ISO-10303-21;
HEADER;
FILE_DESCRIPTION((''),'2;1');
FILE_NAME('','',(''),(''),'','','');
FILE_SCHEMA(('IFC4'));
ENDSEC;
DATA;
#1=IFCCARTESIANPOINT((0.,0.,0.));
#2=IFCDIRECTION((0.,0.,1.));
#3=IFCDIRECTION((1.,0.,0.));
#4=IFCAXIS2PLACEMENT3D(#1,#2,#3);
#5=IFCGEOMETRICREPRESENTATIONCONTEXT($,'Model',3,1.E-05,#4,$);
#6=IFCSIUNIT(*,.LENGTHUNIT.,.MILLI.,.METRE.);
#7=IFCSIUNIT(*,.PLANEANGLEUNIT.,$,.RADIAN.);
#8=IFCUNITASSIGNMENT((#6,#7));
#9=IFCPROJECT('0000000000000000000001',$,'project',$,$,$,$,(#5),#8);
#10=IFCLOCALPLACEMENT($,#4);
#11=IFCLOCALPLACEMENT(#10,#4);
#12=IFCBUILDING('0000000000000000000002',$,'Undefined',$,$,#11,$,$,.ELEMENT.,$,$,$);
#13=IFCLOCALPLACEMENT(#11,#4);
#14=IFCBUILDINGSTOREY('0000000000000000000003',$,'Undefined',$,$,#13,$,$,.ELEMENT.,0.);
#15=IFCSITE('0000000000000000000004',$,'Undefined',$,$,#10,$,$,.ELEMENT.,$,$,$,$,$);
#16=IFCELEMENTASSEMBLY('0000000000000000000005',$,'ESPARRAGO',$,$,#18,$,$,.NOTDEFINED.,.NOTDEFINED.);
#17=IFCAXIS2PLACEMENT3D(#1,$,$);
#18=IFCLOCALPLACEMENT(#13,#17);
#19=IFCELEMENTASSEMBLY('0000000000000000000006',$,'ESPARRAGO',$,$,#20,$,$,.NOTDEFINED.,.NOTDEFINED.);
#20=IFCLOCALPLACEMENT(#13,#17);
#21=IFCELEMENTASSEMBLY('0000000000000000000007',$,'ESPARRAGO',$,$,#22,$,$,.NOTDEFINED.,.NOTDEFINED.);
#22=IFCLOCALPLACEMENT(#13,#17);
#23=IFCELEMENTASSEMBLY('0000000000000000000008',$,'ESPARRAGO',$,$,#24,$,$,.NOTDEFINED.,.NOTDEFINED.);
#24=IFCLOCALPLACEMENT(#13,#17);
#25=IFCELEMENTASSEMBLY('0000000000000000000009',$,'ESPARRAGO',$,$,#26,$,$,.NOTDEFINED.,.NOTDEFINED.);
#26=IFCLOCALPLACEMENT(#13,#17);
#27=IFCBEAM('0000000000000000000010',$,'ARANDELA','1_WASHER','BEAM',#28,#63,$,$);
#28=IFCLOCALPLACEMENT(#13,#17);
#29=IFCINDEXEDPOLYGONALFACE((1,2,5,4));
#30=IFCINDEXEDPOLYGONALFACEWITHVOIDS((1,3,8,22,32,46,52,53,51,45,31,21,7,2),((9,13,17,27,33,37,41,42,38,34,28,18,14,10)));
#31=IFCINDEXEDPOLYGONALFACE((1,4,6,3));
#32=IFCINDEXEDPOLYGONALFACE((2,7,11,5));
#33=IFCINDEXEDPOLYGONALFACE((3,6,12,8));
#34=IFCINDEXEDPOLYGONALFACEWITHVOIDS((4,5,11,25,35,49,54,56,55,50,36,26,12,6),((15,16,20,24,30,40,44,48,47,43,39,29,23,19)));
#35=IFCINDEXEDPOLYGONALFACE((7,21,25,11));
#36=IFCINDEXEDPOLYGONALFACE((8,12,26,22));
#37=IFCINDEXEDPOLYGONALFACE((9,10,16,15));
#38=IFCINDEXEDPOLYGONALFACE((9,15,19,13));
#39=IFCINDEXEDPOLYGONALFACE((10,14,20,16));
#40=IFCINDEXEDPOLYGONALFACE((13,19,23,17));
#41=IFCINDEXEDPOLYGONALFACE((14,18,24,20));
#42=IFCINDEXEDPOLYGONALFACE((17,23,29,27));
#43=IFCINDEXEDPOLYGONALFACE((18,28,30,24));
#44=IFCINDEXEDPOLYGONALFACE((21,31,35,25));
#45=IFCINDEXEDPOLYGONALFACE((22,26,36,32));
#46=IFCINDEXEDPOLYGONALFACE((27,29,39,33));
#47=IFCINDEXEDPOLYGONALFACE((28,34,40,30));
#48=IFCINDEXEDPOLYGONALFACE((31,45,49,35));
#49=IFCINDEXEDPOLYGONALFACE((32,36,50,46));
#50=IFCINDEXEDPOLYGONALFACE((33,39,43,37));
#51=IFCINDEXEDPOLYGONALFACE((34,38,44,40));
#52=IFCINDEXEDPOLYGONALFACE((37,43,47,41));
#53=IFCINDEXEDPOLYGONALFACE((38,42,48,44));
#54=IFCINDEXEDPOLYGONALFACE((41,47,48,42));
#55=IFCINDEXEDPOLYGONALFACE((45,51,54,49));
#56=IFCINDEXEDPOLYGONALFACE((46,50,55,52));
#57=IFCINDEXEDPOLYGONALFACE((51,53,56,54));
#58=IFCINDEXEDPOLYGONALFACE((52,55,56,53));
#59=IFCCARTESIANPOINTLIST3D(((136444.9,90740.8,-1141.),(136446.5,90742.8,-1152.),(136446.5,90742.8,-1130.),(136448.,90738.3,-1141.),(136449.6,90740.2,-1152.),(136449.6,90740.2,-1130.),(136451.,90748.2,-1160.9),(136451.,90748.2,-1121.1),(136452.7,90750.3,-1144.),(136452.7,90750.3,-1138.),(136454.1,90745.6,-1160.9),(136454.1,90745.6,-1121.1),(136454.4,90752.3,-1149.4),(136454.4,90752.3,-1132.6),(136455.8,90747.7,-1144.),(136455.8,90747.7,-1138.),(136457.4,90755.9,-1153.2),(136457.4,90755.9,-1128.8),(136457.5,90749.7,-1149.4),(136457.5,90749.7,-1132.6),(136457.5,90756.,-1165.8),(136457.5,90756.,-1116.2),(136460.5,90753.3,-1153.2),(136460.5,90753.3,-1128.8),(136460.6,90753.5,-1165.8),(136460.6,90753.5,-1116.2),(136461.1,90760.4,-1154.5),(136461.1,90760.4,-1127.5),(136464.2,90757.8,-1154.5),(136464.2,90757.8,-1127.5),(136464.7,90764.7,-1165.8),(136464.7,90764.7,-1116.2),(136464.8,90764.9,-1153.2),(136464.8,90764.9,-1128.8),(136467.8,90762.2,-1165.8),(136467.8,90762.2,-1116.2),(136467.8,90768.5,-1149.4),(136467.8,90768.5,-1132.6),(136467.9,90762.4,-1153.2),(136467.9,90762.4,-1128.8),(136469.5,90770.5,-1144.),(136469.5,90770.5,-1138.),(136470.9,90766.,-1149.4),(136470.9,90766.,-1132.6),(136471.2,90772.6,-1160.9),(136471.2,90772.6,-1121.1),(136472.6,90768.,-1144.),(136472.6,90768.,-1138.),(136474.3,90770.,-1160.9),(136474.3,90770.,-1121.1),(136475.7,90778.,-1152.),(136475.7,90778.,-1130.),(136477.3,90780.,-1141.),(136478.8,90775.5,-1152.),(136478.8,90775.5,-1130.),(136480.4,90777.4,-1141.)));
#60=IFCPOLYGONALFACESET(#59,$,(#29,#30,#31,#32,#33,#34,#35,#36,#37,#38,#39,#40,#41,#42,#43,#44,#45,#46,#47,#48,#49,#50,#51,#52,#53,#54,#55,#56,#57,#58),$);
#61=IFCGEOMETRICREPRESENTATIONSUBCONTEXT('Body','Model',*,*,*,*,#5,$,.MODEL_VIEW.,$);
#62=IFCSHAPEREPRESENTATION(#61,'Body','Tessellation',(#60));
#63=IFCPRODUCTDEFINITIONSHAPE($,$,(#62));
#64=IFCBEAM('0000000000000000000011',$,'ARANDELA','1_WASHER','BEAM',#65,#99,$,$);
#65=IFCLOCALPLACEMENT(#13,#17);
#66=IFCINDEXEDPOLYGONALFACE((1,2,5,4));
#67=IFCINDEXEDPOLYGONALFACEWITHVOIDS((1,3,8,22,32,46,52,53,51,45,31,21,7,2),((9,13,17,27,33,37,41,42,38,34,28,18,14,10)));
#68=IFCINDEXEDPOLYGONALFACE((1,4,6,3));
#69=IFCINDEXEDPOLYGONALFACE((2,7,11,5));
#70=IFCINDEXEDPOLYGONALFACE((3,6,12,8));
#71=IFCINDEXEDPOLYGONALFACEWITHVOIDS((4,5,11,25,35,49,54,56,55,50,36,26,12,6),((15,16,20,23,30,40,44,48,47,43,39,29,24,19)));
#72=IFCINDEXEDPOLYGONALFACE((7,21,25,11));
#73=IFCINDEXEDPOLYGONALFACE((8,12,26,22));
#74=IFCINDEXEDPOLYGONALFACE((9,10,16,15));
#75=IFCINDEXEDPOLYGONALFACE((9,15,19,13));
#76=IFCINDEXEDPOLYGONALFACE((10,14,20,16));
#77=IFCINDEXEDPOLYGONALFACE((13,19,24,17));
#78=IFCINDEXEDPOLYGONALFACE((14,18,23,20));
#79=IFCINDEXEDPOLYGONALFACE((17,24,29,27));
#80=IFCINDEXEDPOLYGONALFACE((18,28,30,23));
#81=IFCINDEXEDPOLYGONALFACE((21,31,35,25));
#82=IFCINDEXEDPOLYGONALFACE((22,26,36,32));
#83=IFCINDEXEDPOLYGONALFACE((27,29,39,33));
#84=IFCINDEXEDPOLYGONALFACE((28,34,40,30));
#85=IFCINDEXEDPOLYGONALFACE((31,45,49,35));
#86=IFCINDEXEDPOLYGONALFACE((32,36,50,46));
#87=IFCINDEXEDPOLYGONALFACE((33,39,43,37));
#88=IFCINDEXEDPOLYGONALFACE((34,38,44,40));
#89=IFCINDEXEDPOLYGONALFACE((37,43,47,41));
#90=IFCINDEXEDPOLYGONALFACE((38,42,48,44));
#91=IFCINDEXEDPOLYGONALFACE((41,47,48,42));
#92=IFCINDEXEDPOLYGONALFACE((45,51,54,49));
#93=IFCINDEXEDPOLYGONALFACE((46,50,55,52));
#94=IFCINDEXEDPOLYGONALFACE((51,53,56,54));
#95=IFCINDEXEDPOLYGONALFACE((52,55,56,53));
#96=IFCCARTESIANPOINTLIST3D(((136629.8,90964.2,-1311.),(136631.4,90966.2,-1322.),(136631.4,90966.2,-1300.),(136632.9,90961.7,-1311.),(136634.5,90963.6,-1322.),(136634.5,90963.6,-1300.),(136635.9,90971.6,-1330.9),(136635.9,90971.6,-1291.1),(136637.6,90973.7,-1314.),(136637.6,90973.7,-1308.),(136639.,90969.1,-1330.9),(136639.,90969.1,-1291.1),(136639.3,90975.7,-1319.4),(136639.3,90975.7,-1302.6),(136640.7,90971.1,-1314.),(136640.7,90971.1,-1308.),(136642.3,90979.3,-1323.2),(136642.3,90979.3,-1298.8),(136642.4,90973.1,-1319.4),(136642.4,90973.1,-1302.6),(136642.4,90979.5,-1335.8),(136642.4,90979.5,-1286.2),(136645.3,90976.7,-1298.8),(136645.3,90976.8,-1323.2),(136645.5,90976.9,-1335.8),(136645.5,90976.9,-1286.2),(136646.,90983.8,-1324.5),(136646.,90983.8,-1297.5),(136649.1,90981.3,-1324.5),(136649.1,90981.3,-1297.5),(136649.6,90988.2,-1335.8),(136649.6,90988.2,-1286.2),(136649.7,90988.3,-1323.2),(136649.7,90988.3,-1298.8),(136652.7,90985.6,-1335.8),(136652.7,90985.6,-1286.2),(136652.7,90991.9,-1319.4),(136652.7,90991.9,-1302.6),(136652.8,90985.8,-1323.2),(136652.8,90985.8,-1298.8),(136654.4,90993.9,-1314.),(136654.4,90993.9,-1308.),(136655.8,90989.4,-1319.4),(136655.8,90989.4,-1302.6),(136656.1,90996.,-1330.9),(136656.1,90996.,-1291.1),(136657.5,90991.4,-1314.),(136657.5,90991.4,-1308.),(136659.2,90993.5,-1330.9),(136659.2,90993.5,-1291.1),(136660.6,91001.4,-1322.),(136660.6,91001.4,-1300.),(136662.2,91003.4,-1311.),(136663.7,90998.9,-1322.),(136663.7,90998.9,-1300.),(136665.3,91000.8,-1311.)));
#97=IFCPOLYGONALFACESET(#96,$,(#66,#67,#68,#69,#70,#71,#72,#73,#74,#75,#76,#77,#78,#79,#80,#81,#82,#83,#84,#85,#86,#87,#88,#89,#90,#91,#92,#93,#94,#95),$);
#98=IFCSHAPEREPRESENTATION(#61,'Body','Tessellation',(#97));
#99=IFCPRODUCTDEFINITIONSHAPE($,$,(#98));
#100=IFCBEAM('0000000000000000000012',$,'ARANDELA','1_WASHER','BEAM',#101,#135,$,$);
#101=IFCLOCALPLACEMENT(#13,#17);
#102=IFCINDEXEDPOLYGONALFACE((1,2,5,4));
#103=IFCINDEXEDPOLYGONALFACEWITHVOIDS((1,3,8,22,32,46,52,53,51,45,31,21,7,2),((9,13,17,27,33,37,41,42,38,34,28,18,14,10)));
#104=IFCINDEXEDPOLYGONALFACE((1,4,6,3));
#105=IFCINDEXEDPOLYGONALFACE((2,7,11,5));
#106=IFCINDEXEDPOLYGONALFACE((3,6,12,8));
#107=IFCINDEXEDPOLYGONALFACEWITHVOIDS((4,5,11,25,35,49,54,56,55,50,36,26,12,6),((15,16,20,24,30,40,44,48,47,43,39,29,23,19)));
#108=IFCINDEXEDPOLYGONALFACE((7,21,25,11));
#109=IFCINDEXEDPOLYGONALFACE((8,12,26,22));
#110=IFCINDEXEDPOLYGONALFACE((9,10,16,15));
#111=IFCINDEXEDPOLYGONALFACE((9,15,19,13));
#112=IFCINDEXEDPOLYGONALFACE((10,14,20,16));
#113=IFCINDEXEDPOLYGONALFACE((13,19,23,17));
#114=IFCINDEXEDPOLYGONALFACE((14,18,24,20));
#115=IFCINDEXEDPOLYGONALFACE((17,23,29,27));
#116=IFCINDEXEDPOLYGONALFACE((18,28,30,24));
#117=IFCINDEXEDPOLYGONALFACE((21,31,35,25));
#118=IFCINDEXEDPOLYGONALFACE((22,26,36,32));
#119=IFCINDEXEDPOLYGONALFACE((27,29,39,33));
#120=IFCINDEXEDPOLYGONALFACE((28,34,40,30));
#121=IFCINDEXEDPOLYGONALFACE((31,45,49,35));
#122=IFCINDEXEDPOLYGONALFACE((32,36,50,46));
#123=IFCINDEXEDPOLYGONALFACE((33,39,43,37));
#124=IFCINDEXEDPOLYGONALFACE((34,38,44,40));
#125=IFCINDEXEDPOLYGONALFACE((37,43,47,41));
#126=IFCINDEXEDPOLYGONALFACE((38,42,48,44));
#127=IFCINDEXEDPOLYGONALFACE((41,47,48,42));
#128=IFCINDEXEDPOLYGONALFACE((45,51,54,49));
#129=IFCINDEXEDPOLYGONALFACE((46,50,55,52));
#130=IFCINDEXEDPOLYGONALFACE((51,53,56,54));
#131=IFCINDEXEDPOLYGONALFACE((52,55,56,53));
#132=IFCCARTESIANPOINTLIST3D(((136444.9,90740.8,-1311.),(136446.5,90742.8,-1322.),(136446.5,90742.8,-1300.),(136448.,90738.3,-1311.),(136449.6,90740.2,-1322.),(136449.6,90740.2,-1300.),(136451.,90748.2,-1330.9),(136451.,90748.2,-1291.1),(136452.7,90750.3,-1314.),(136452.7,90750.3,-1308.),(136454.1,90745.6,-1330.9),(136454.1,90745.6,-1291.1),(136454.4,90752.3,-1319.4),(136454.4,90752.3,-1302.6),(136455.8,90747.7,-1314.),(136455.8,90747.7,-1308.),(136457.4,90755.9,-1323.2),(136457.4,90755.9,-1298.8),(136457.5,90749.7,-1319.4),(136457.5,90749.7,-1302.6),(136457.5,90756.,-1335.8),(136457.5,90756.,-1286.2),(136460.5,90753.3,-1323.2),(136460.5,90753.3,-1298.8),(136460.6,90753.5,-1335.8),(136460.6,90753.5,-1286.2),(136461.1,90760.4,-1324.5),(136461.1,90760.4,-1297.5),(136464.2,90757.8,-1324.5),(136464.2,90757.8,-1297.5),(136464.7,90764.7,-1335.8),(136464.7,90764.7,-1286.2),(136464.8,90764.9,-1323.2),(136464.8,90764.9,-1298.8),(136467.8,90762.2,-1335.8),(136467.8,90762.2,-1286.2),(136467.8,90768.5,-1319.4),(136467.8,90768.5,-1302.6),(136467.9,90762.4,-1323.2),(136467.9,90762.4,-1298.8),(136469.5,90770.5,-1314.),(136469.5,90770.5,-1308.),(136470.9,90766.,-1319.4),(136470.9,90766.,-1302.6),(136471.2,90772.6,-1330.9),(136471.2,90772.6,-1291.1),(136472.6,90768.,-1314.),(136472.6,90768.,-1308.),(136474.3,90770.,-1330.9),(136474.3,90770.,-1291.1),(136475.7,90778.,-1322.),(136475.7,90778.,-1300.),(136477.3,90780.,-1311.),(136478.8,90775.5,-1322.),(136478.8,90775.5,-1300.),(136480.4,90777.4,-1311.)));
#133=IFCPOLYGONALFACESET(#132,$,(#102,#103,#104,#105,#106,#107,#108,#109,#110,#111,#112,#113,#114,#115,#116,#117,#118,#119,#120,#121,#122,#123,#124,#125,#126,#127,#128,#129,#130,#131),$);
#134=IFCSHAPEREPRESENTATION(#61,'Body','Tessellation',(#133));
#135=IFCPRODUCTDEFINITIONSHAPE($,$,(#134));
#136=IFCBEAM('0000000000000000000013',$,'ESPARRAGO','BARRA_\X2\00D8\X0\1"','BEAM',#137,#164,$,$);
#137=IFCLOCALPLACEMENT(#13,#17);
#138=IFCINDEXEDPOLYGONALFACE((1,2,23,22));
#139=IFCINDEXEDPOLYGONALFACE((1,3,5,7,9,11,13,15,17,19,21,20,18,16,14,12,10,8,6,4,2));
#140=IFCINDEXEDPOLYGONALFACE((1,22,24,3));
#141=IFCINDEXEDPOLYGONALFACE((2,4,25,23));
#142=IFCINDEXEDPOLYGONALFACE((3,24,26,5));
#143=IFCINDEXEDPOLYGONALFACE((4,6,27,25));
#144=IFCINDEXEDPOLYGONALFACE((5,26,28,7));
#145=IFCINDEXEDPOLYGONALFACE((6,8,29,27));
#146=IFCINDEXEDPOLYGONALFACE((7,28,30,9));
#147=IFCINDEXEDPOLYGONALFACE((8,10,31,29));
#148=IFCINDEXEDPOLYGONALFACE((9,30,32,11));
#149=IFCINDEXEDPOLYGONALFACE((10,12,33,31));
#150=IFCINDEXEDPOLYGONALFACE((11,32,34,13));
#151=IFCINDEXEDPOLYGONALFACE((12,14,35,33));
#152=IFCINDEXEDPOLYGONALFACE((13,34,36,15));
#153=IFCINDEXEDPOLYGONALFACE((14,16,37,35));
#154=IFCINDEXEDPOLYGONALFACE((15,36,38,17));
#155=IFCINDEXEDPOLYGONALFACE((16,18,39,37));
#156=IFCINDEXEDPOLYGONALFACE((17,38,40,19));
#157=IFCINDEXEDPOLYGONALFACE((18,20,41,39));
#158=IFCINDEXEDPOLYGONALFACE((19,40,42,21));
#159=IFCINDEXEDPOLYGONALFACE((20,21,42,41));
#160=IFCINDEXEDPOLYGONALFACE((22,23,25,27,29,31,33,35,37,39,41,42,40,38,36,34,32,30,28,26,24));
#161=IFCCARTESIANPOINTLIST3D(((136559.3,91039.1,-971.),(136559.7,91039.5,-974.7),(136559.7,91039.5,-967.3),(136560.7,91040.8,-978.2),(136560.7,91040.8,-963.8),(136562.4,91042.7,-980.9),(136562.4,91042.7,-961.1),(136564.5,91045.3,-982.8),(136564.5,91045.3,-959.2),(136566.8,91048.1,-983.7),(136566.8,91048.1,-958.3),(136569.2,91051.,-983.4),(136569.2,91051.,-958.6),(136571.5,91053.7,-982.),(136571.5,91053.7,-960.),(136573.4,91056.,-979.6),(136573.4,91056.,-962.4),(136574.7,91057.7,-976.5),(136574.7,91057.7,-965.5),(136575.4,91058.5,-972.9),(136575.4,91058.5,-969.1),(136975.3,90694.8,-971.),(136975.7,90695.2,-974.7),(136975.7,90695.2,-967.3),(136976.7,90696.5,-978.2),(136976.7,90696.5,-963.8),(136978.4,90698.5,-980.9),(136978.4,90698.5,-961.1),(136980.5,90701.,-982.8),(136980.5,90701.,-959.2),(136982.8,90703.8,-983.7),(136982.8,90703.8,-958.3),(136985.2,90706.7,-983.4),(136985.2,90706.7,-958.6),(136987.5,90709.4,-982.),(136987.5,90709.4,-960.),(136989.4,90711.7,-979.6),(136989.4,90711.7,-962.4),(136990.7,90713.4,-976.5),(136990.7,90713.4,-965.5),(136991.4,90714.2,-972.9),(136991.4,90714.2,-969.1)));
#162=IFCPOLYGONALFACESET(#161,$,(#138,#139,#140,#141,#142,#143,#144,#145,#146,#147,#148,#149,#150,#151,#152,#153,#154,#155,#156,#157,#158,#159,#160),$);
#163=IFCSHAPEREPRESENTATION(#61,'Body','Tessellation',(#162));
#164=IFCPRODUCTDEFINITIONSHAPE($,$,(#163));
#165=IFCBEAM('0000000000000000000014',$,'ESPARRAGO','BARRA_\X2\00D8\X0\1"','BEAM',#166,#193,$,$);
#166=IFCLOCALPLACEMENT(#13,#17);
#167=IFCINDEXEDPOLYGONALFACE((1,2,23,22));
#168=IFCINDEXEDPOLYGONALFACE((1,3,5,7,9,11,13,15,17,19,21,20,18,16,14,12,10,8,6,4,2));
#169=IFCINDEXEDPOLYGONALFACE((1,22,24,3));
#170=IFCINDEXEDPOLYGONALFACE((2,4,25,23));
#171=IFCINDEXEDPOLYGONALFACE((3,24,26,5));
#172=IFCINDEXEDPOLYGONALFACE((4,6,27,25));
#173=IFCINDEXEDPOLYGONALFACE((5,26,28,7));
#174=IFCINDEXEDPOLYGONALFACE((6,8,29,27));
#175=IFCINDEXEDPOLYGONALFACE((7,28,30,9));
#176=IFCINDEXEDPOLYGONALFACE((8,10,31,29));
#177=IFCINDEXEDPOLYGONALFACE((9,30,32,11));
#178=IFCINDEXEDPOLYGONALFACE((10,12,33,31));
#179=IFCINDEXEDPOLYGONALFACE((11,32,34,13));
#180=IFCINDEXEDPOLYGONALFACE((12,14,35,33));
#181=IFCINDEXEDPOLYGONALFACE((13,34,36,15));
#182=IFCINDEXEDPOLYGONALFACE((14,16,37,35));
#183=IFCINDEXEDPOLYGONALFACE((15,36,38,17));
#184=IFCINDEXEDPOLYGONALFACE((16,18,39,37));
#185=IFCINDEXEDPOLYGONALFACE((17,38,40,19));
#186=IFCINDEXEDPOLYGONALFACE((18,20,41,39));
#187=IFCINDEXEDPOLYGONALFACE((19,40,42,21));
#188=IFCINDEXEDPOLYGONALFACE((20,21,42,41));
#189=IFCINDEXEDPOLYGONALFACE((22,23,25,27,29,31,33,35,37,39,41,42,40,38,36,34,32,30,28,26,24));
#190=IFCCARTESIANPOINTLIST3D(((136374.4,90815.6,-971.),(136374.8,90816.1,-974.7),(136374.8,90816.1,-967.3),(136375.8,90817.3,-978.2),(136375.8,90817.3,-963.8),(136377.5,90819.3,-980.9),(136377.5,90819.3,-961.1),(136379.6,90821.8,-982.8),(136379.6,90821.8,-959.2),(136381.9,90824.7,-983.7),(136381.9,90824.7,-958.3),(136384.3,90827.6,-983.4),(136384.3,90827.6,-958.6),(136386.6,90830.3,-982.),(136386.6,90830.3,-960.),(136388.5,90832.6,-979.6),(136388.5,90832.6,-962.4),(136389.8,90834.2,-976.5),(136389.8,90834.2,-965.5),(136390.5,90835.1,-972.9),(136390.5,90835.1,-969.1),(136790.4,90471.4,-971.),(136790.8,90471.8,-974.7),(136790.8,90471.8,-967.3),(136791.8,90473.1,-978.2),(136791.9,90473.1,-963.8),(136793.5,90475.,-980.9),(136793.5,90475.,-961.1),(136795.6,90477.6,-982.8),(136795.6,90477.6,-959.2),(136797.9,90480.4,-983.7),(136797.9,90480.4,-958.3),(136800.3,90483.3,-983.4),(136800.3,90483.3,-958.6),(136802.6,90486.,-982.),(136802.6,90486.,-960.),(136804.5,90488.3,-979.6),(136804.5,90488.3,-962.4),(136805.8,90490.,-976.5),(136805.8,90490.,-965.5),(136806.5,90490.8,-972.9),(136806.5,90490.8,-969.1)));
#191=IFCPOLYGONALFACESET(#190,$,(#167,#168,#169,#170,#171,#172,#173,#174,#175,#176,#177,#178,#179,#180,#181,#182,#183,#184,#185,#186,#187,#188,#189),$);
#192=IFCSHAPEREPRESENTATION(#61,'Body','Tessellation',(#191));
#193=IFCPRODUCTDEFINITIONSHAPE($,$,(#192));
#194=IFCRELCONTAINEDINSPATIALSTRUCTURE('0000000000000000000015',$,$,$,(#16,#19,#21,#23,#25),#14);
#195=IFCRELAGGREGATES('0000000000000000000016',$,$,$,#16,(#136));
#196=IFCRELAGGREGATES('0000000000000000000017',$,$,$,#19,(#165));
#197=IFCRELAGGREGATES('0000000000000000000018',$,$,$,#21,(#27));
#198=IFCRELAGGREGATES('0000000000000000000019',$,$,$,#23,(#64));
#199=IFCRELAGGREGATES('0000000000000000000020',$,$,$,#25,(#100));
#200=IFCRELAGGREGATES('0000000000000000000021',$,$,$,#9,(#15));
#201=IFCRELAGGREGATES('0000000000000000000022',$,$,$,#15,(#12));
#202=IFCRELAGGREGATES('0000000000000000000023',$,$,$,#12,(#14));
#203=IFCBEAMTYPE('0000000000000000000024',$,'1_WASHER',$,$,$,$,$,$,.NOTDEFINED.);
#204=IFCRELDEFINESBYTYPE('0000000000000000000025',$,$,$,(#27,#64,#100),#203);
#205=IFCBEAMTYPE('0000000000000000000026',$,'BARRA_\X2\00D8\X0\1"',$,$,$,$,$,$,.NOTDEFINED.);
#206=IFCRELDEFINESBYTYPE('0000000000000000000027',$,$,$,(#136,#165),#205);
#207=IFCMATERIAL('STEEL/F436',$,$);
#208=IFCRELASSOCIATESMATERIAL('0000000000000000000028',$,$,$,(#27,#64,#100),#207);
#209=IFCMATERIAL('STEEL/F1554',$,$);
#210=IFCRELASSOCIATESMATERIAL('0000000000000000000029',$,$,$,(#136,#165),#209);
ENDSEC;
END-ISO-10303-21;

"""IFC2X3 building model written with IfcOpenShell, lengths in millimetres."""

from ifc_helpers import new_model, si_unit, frame, origin_with_axes, origin_2d_with_axis, place, context, subcontext, project, spatial, polyline, circle, outline, extrude, material, type_object, element, aggregate, save


model = new_model("IFC2X3")

# Units and contexts
model_context = context("Model", 3, precision=1e-05, world=origin_with_axes())
body_context = subcontext(model_context, "Body", "Model", "MODEL_VIEW")
ifc_project = project(units=[si_unit("LENGTHUNIT", "METRE", prefix="MILLI"), si_unit("PLANEANGLEUNIT", "RADIAN")], contexts=[model_context])

# Site, building, storey
site_placement = place(None, origin_with_axes())
site = spatial("IfcSite", under=ifc_project, at=site_placement, Name="Undefined", CompositionType="ELEMENT")
building_placement = place(site_placement, origin_with_axes())
building = spatial("IfcBuilding", under=site, at=building_placement, Name="Undefined", CompositionType="ELEMENT")
storey_placement = place(building_placement, origin_with_axes())
storey = spatial("IfcBuildingStorey", under=building, at=storey_placement, Name="Undefined", CompositionType="ELEMENT", Elevation=0.0)

# Element assemblies
assembly_1_placement = place(storey_placement, origin_with_axes())
assembly_1 = element("IfcElementAssembly", 1, at=assembly_1_placement, inside=storey, Name="ESPARRAGO", AssemblyPlace="NOTDEFINED", PredefinedType="NOTDEFINED")
assembly_2_placement = place(storey_placement, origin_with_axes())
assembly_2 = element("IfcElementAssembly", 2, at=assembly_2_placement, inside=storey, Name="ESPARRAGO", AssemblyPlace="NOTDEFINED", PredefinedType="NOTDEFINED")
assembly_3_placement = place(storey_placement, origin_with_axes())
assembly_3 = element("IfcElementAssembly", 3, at=assembly_3_placement, inside=storey, Name="ESPARRAGO", AssemblyPlace="NOTDEFINED", PredefinedType="NOTDEFINED")
assembly_4_placement = place(storey_placement, origin_with_axes())
assembly_4 = element("IfcElementAssembly", 4, at=assembly_4_placement, inside=storey, Name="ESPARRAGO", AssemblyPlace="NOTDEFINED", PredefinedType="NOTDEFINED")
assembly_5_placement = place(storey_placement, origin_with_axes())
assembly_5 = element("IfcElementAssembly", 5, at=assembly_5_placement, inside=storey, Name="ESPARRAGO", AssemblyPlace="NOTDEFINED", PredefinedType="NOTDEFINED")

# Beams
ifc_material_1 = material(Name="STEEL/F436")
beam_type_1 = type_object("IfcBeamType", Name="1_WASHER", PredefinedType="NOTDEFINED")
beam_1_placement = place(assembly_3_placement, frame((136461.1, 90760.4, -1141.0), z_axis=(0.000066, -0.000055, 1.0), x_axis=(0.770401, -0.63756, -0.000086)))
beam_1 = element("IfcBeam", 6, at=beam_1_placement, type_object=beam_type_1, material=ifc_material_1, Name="ARANDELA", Description="1_WASHER", ObjectType="BEAM", context=body_context, shape_type="SweptSolid", body=[
    extrude(outline(polyline([(-15.8, -19.9), (-22.9, -11.0), (-25.4, 0.0), (-22.9, 11.0), (-15.8, 19.9), (-5.7, 24.8), (5.7, 24.8), (15.8, 19.9), (22.9, 11.0), (25.4, 0.0), (22.9, -11.0), (15.8, -19.9), (5.7, -24.8), (-5.7, -24.8), (-15.8, -19.9)]), holes=[polyline([(-5.9, 12.2), (-10.5, 8.4), (-13.2, 3.0), (-13.2, -3.0), (-10.5, -8.4), (-5.9, -12.2), (0.0, -13.5), (5.9, -12.2), (10.5, -8.4), (13.2, -3.0), (13.2, 3.0), (10.5, 8.4), (5.9, 12.2), (0.0, 13.5), (-5.9, 12.2)])]), frame((4.0, 0.0, 0.0), z_axis=(-1.0, 0.0, 0.0), x_axis=(0.0, -1.0, 0.0)), (0.0, 0.0, 1.0), 4.0),
])
beam_2_placement = place(assembly_4_placement, frame((136646.0, 90983.8, -1311.0), z_axis=(0.000066, -0.000055, 1.0), x_axis=(0.770401, -0.63756, -0.000086)))
beam_2 = element("IfcBeam", 7, at=beam_2_placement, type_object=beam_type_1, material=ifc_material_1, Name="ARANDELA", Description="1_WASHER", ObjectType="BEAM", context=body_context, shape_type="SweptSolid", body=[
    extrude(outline(polyline([(-15.8, -19.9), (-22.9, -11.0), (-25.4, 0.0), (-22.9, 11.0), (-15.8, 19.9), (-5.7, 24.8), (5.7, 24.8), (15.8, 19.9), (22.9, 11.0), (25.4, 0.0), (22.9, -11.0), (15.8, -19.9), (5.7, -24.8), (-5.7, -24.8), (-15.8, -19.9)]), holes=[polyline([(-5.9, 12.2), (-10.5, 8.4), (-13.2, 3.0), (-13.2, -3.0), (-10.5, -8.4), (-5.9, -12.2), (0.0, -13.5), (5.9, -12.2), (10.5, -8.4), (13.2, -3.0), (13.2, 3.0), (10.5, 8.4), (5.9, 12.2), (0.0, 13.5), (-5.9, 12.2)])]), frame((4.0, 0.0, 0.0), z_axis=(-1.0, 0.0, 0.0), x_axis=(0.0, -1.0, 0.0)), (0.0, 0.0, 1.0), 4.0),
])
beam_3_placement = place(assembly_5_placement, frame((136461.1, 90760.4, -1311.0), z_axis=(0.000066, -0.000055, 1.0), x_axis=(0.770401, -0.63756, -0.000086)))
beam_3 = element("IfcBeam", 8, at=beam_3_placement, type_object=beam_type_1, material=ifc_material_1, Name="ARANDELA", Description="1_WASHER", ObjectType="BEAM", context=body_context, shape_type="SweptSolid", body=[
    extrude(outline(polyline([(-15.8, -19.9), (-22.9, -11.0), (-25.4, 0.0), (-22.9, 11.0), (-15.8, 19.9), (-5.7, 24.8), (5.7, 24.8), (15.8, 19.9), (22.9, 11.0), (25.4, 0.0), (22.9, -11.0), (15.8, -19.9), (5.7, -24.8), (-5.7, -24.8), (-15.8, -19.9)]), holes=[polyline([(-5.9, 12.2), (-10.5, 8.4), (-13.2, 3.0), (-13.2, -3.0), (-10.5, -8.4), (-5.9, -12.2), (0.0, -13.5), (5.9, -12.2), (10.5, -8.4), (13.2, -3.0), (13.2, 3.0), (10.5, 8.4), (5.9, 12.2), (0.0, 13.5), (-5.9, 12.2)])]), frame((4.0, 0.0, 0.0), z_axis=(-1.0, 0.0, 0.0), x_axis=(0.0, -1.0, 0.0)), (0.0, 0.0, 1.0), 4.0),
])
ifc_material_2 = material(Name="STEEL/F1554")
beam_type_2 = type_object("IfcBeamType", Name="BARRA_Ø1\"", PredefinedType="NOTDEFINED")
beam_4_placement = place(assembly_1_placement, frame((136567.4, 91048.8, -971.0), z_axis=(0.000003, -0.000003, 1.0), x_axis=(0.770403, -0.637557, -0.000004)))
beam_4 = element("IfcBeam", 9, at=beam_4_placement, type_object=beam_type_2, material=ifc_material_2, Name="ESPARRAGO", Description="BARRA_Ø1\"", ObjectType="BEAM", context=body_context, shape_type="SweptSolid", body=[
    extrude(circle(Radius=12.7, at=origin_2d_with_axis()), frame((540.0, 0.0, 0.0), z_axis=(-1.0, 0.0, 0.0), x_axis=(0.0, -1.0, 0.0)), (0.0, 0.0, 1.0), 540.0),
])
aggregate(assembly_1, [beam_4])
beam_5_placement = place(assembly_2_placement, frame((136382.5, 90825.4, -971.0), z_axis=(0.000003, -0.000003, 1.0), x_axis=(0.770403, -0.637557, -0.000004)))
beam_5 = element("IfcBeam", 10, at=beam_5_placement, type_object=beam_type_2, material=ifc_material_2, Name="ESPARRAGO", Description="BARRA_Ø1\"", ObjectType="BEAM", context=body_context, shape_type="SweptSolid", body=[
    extrude(circle(Radius=12.7, at=origin_2d_with_axis()), frame((540.0, 0.0, 0.0), z_axis=(-1.0, 0.0, 0.0), x_axis=(0.0, -1.0, 0.0)), (0.0, 0.0, 1.0), 540.0),
])
aggregate(assembly_2, [beam_5])
aggregate(assembly_3, [beam_1])
aggregate(assembly_4, [beam_2])
aggregate(assembly_5, [beam_3])

save(model, "model.ifc")
